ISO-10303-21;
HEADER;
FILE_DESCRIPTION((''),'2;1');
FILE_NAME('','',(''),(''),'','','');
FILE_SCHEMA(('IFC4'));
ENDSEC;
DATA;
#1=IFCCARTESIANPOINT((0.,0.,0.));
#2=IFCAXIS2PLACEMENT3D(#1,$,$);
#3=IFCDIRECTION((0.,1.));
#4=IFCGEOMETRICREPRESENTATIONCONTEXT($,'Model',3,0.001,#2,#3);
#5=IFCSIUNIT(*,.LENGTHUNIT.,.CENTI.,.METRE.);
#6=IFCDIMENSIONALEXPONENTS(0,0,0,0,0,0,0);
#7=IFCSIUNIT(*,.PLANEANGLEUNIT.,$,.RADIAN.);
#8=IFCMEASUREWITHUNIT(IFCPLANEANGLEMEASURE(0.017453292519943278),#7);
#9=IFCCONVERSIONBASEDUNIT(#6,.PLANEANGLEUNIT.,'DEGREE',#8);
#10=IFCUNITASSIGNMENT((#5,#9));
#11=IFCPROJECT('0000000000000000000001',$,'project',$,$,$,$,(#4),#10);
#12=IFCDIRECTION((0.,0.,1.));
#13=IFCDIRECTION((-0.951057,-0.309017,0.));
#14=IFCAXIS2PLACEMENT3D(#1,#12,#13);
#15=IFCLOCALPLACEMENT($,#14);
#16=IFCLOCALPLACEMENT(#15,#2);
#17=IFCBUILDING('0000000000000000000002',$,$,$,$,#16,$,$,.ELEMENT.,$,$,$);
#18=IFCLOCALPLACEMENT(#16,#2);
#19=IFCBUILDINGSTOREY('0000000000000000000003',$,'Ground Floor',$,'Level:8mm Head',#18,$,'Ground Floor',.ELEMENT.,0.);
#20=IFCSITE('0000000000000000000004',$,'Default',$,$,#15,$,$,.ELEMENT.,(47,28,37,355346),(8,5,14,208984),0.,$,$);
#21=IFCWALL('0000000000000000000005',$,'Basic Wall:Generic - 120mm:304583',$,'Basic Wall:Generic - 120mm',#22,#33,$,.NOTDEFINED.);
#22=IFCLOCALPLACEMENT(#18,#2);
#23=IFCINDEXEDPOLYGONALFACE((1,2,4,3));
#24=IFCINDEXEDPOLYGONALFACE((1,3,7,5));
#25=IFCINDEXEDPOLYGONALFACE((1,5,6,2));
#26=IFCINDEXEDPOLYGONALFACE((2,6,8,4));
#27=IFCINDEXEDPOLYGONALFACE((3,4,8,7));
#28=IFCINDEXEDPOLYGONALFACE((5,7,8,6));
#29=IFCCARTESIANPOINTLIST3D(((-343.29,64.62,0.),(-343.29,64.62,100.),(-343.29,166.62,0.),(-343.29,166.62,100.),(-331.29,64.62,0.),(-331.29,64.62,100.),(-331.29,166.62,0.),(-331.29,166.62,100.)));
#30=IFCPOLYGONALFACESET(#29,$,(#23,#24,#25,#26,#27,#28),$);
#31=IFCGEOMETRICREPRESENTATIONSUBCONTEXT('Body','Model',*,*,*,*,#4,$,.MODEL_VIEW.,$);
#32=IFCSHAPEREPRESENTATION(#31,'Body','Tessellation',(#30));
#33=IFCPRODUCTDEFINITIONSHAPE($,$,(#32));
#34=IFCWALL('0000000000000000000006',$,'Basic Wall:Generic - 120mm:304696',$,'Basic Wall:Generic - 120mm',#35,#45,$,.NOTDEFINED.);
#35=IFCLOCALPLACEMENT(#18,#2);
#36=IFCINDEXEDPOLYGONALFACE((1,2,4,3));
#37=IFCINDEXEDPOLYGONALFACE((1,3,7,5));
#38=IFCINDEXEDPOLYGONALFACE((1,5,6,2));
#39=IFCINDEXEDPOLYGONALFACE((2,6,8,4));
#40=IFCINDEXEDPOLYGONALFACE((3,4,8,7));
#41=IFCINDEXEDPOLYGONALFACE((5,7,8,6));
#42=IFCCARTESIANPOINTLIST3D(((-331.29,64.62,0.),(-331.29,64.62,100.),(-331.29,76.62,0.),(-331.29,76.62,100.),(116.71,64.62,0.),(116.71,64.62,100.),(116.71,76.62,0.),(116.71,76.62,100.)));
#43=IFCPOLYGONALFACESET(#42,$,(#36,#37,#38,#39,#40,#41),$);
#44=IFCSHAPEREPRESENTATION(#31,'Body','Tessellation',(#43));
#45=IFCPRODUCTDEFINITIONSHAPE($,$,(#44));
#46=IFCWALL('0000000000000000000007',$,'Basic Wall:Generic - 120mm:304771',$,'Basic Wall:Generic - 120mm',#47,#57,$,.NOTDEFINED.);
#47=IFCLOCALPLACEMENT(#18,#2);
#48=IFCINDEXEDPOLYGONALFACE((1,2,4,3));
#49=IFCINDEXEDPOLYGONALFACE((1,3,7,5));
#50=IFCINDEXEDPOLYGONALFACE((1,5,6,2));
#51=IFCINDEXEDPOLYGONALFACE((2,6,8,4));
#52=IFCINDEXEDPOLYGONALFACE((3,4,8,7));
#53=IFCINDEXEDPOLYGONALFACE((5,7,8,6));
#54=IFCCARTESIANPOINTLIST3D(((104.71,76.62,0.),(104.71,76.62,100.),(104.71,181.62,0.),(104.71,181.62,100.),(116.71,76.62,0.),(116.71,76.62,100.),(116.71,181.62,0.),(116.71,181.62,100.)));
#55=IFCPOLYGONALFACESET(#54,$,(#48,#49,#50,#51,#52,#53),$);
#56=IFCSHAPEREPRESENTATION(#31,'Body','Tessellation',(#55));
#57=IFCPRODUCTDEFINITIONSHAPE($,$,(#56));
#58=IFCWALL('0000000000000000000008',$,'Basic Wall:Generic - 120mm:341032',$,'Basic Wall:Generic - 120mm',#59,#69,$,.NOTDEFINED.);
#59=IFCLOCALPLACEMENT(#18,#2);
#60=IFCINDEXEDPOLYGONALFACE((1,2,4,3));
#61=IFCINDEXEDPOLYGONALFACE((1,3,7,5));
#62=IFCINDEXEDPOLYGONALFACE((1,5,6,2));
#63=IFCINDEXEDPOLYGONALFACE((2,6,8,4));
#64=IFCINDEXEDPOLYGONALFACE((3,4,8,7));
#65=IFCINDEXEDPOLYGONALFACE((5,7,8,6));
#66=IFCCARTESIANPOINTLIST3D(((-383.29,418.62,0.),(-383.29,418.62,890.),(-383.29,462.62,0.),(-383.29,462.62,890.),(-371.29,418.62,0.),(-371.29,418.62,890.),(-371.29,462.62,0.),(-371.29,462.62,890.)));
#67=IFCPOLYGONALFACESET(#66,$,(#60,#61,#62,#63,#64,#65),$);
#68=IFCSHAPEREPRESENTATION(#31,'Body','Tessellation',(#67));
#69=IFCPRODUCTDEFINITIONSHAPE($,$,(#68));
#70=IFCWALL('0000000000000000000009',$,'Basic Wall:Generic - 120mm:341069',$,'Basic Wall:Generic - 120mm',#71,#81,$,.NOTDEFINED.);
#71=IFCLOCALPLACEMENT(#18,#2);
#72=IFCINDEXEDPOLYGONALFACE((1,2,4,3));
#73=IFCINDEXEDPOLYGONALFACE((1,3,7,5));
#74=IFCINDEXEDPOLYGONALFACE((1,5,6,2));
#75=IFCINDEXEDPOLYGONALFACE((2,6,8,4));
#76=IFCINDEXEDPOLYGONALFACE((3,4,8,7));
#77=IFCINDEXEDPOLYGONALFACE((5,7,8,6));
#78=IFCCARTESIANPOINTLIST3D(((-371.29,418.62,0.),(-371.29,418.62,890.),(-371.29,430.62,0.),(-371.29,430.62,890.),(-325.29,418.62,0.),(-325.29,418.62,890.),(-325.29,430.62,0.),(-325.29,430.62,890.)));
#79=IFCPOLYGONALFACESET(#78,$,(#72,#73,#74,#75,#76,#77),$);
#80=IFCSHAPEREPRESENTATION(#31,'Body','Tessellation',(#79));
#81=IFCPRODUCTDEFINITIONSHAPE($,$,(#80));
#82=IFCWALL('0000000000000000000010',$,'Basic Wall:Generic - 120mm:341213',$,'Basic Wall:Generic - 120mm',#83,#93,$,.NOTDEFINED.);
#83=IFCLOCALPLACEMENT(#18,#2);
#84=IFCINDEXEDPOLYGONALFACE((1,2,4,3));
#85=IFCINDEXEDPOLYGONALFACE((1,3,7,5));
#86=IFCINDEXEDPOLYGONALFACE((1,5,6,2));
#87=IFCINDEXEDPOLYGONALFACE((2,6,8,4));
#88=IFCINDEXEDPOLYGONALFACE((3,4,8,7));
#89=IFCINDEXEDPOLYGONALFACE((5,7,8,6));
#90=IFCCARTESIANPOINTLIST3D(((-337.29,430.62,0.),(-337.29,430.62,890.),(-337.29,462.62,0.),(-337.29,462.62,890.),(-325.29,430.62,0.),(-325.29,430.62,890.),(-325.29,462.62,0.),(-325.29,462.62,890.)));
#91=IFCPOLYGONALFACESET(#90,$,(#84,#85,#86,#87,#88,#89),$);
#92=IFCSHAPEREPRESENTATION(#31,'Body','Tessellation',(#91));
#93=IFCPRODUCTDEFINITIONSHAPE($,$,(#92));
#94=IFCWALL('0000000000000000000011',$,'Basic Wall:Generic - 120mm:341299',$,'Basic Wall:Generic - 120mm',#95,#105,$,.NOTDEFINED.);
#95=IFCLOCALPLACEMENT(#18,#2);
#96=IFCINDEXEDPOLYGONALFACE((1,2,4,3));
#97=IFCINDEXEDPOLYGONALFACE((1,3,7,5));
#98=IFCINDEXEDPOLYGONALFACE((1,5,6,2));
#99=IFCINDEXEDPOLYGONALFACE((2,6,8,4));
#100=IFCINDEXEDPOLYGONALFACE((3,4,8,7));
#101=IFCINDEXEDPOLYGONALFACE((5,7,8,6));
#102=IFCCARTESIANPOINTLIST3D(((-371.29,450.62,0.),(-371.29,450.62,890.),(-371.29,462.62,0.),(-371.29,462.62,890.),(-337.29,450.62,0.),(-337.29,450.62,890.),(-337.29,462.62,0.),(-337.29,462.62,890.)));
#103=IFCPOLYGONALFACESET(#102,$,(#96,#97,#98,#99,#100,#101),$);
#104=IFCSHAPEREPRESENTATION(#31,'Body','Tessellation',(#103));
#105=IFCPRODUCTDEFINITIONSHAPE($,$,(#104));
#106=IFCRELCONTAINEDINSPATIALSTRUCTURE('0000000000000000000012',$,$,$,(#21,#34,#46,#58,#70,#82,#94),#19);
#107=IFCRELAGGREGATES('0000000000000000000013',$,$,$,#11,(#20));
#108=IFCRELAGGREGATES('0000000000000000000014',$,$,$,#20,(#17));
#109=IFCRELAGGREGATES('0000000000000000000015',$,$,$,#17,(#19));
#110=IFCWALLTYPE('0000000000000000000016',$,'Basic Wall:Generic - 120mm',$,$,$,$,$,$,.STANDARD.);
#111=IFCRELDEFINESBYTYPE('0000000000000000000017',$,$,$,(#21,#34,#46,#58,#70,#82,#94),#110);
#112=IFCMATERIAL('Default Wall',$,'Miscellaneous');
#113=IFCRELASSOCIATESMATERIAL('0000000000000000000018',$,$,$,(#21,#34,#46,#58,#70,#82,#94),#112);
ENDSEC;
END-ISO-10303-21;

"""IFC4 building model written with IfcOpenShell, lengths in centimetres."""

from ifc_helpers import new_model, entity, si_unit, converted_unit, direction, frame, origin, place, context, subcontext, project, spatial, indexed_curve, outline, extrude, material, type_object, element, save


model = new_model("IFC4")

# Units and contexts
model_context = context("Model", 3, precision=0.001, world=origin(), true_north=direction((0.0, 1.0)))
body_context = subcontext(model_context, "Body", "Model", "MODEL_VIEW")
ifc_project = project(units=[si_unit("LENGTHUNIT", "METRE", prefix="CENTI"), converted_unit("PLANEANGLEUNIT", "DEGREE", entity("IfcPlaneAngleMeasure", 0.017453292519943278), si_unit("PLANEANGLEUNIT", "RADIAN"), dimensions=[0, 0, 0, 0, 0, 0, 0])], contexts=[model_context])

# Site, building, storey
site_placement = place(None, frame((0.0, 0.0, 0.0), z_axis=(0.0, 0.0, 1.0), x_axis=(-0.951057, -0.309017, 0.0)))
site = spatial("IfcSite", under=ifc_project, at=site_placement, Name="Default", CompositionType="ELEMENT", RefLatitude=(47, 28, 37, 355346), RefLongitude=(8, 5, 14, 208984), RefElevation=0.0)
building_placement = place(site_placement, origin())
building = spatial("IfcBuilding", under=site, at=building_placement, CompositionType="ELEMENT")
storey_placement = place(building_placement, origin())
storey = spatial("IfcBuildingStorey", under=building, at=storey_placement, Name="Ground Floor", ObjectType="Level:8mm Head", LongName="Ground Floor", CompositionType="ELEMENT", Elevation=0.0)

# Walls
ifc_material_1 = material(Name="Default Wall", Category="Miscellaneous")
wall_type = type_object("IfcWallType", Name="Basic Wall:Generic - 120mm", PredefinedType="STANDARD")
wall_1_placement = place(storey_placement, frame((-337.29, 166.62, 0.0), z_axis=(0.0, 0.0, 1.0), x_axis=(0.0, -1.0, 0.0)))
element("IfcWall", 1, at=wall_1_placement, inside=storey, type_object=wall_type, material=ifc_material_1, Name="Basic Wall:Generic - 120mm:304583", ObjectType="Basic Wall:Generic - 120mm", PredefinedType="NOTDEFINED", context=body_context, shape_type="SweptSolid", body=[
    extrude(outline(indexed_curve([(102.0, 6.0), (0.0, 6.0), (0.0, -6.0), (102.0, -6.0), (102.0, 6.0)], self_intersect=False)), origin(), (0.0, 0.0, 1.0), 100.0),
])
wall_2_placement = place(storey_placement, frame((-331.29, 70.62, 0.0)))
element("IfcWall", 2, at=wall_2_placement, inside=storey, type_object=wall_type, material=ifc_material_1, Name="Basic Wall:Generic - 120mm:304696", ObjectType="Basic Wall:Generic - 120mm", PredefinedType="NOTDEFINED", context=body_context, shape_type="SweptSolid", body=[
    extrude(outline(indexed_curve([(448.0, 6.0), (0.0, 6.0), (0.0, -6.0), (448.0, -6.0), (448.0, 6.0)], self_intersect=False)), origin(), (0.0, 0.0, 1.0), 100.0),
])
wall_3_placement = place(storey_placement, frame((110.71, 76.62, 0.0), z_axis=(0.0, 0.0, 1.0), x_axis=(0.0, 1.0, 0.0)))
element("IfcWall", 3, at=wall_3_placement, inside=storey, type_object=wall_type, material=ifc_material_1, Name="Basic Wall:Generic - 120mm:304771", ObjectType="Basic Wall:Generic - 120mm", PredefinedType="NOTDEFINED", context=body_context, shape_type="SweptSolid", body=[
    extrude(outline(indexed_curve([(105.0, 6.0), (0.0, 6.0), (0.0, -6.0), (105.0, -6.0), (105.0, 6.0)], self_intersect=False)), origin(), (0.0, 0.0, 1.0), 100.0),
])
wall_4_placement = place(storey_placement, frame((-377.29, 462.62, 0.0), z_axis=(0.0, 0.0, 1.0), x_axis=(0.0, -1.0, 0.0)))
element("IfcWall", 4, at=wall_4_placement, inside=storey, type_object=wall_type, material=ifc_material_1, Name="Basic Wall:Generic - 120mm:341032", ObjectType="Basic Wall:Generic - 120mm", PredefinedType="NOTDEFINED", context=body_context, shape_type="SweptSolid", body=[
    extrude(outline(indexed_curve([(44.0, 6.0), (0.0, 6.0), (0.0, -6.0), (44.0, -6.0), (44.0, 6.0)], self_intersect=False)), origin(), (0.0, 0.0, 1.0), 890.0),
])
wall_5_placement = place(storey_placement, frame((-371.29, 424.62, 0.0)))
element("IfcWall", 5, at=wall_5_placement, inside=storey, type_object=wall_type, material=ifc_material_1, Name="Basic Wall:Generic - 120mm:341069", ObjectType="Basic Wall:Generic - 120mm", PredefinedType="NOTDEFINED", context=body_context, shape_type="SweptSolid", body=[
    extrude(outline(indexed_curve([(46.0, 6.0), (0.0, 6.0), (0.0, -6.0), (46.0, -6.0), (46.0, 6.0)], self_intersect=False)), origin(), (0.0, 0.0, 1.0), 890.0),
])
wall_6_placement = place(storey_placement, frame((-331.29, 430.62, 0.0), z_axis=(0.0, 0.0, 1.0), x_axis=(0.0, 1.0, 0.0)))
element("IfcWall", 6, at=wall_6_placement, inside=storey, type_object=wall_type, material=ifc_material_1, Name="Basic Wall:Generic - 120mm:341213", ObjectType="Basic Wall:Generic - 120mm", PredefinedType="NOTDEFINED", context=body_context, shape_type="SweptSolid", body=[
    extrude(outline(indexed_curve([(32.0, 6.0), (0.0, 6.0), (0.0, -6.0), (32.0, -6.0), (32.0, 6.0)], self_intersect=False)), origin(), (0.0, 0.0, 1.0), 890.0),
])
wall_7_placement = place(storey_placement, frame((-337.29, 456.62, 0.0), z_axis=(0.0, 0.0, 1.0), x_axis=(-1.0, 0.0, 0.0)))
element("IfcWall", 7, at=wall_7_placement, inside=storey, type_object=wall_type, material=ifc_material_1, Name="Basic Wall:Generic - 120mm:341299", ObjectType="Basic Wall:Generic - 120mm", PredefinedType="NOTDEFINED", context=body_context, shape_type="SweptSolid", body=[
    extrude(outline(indexed_curve([(34.0, 6.0), (0.0, 6.0), (0.0, -6.0), (34.0, -6.0), (34.0, 6.0)], self_intersect=False)), origin(), (0.0, 0.0, 1.0), 890.0),
])

save(model, "model.ifc")
